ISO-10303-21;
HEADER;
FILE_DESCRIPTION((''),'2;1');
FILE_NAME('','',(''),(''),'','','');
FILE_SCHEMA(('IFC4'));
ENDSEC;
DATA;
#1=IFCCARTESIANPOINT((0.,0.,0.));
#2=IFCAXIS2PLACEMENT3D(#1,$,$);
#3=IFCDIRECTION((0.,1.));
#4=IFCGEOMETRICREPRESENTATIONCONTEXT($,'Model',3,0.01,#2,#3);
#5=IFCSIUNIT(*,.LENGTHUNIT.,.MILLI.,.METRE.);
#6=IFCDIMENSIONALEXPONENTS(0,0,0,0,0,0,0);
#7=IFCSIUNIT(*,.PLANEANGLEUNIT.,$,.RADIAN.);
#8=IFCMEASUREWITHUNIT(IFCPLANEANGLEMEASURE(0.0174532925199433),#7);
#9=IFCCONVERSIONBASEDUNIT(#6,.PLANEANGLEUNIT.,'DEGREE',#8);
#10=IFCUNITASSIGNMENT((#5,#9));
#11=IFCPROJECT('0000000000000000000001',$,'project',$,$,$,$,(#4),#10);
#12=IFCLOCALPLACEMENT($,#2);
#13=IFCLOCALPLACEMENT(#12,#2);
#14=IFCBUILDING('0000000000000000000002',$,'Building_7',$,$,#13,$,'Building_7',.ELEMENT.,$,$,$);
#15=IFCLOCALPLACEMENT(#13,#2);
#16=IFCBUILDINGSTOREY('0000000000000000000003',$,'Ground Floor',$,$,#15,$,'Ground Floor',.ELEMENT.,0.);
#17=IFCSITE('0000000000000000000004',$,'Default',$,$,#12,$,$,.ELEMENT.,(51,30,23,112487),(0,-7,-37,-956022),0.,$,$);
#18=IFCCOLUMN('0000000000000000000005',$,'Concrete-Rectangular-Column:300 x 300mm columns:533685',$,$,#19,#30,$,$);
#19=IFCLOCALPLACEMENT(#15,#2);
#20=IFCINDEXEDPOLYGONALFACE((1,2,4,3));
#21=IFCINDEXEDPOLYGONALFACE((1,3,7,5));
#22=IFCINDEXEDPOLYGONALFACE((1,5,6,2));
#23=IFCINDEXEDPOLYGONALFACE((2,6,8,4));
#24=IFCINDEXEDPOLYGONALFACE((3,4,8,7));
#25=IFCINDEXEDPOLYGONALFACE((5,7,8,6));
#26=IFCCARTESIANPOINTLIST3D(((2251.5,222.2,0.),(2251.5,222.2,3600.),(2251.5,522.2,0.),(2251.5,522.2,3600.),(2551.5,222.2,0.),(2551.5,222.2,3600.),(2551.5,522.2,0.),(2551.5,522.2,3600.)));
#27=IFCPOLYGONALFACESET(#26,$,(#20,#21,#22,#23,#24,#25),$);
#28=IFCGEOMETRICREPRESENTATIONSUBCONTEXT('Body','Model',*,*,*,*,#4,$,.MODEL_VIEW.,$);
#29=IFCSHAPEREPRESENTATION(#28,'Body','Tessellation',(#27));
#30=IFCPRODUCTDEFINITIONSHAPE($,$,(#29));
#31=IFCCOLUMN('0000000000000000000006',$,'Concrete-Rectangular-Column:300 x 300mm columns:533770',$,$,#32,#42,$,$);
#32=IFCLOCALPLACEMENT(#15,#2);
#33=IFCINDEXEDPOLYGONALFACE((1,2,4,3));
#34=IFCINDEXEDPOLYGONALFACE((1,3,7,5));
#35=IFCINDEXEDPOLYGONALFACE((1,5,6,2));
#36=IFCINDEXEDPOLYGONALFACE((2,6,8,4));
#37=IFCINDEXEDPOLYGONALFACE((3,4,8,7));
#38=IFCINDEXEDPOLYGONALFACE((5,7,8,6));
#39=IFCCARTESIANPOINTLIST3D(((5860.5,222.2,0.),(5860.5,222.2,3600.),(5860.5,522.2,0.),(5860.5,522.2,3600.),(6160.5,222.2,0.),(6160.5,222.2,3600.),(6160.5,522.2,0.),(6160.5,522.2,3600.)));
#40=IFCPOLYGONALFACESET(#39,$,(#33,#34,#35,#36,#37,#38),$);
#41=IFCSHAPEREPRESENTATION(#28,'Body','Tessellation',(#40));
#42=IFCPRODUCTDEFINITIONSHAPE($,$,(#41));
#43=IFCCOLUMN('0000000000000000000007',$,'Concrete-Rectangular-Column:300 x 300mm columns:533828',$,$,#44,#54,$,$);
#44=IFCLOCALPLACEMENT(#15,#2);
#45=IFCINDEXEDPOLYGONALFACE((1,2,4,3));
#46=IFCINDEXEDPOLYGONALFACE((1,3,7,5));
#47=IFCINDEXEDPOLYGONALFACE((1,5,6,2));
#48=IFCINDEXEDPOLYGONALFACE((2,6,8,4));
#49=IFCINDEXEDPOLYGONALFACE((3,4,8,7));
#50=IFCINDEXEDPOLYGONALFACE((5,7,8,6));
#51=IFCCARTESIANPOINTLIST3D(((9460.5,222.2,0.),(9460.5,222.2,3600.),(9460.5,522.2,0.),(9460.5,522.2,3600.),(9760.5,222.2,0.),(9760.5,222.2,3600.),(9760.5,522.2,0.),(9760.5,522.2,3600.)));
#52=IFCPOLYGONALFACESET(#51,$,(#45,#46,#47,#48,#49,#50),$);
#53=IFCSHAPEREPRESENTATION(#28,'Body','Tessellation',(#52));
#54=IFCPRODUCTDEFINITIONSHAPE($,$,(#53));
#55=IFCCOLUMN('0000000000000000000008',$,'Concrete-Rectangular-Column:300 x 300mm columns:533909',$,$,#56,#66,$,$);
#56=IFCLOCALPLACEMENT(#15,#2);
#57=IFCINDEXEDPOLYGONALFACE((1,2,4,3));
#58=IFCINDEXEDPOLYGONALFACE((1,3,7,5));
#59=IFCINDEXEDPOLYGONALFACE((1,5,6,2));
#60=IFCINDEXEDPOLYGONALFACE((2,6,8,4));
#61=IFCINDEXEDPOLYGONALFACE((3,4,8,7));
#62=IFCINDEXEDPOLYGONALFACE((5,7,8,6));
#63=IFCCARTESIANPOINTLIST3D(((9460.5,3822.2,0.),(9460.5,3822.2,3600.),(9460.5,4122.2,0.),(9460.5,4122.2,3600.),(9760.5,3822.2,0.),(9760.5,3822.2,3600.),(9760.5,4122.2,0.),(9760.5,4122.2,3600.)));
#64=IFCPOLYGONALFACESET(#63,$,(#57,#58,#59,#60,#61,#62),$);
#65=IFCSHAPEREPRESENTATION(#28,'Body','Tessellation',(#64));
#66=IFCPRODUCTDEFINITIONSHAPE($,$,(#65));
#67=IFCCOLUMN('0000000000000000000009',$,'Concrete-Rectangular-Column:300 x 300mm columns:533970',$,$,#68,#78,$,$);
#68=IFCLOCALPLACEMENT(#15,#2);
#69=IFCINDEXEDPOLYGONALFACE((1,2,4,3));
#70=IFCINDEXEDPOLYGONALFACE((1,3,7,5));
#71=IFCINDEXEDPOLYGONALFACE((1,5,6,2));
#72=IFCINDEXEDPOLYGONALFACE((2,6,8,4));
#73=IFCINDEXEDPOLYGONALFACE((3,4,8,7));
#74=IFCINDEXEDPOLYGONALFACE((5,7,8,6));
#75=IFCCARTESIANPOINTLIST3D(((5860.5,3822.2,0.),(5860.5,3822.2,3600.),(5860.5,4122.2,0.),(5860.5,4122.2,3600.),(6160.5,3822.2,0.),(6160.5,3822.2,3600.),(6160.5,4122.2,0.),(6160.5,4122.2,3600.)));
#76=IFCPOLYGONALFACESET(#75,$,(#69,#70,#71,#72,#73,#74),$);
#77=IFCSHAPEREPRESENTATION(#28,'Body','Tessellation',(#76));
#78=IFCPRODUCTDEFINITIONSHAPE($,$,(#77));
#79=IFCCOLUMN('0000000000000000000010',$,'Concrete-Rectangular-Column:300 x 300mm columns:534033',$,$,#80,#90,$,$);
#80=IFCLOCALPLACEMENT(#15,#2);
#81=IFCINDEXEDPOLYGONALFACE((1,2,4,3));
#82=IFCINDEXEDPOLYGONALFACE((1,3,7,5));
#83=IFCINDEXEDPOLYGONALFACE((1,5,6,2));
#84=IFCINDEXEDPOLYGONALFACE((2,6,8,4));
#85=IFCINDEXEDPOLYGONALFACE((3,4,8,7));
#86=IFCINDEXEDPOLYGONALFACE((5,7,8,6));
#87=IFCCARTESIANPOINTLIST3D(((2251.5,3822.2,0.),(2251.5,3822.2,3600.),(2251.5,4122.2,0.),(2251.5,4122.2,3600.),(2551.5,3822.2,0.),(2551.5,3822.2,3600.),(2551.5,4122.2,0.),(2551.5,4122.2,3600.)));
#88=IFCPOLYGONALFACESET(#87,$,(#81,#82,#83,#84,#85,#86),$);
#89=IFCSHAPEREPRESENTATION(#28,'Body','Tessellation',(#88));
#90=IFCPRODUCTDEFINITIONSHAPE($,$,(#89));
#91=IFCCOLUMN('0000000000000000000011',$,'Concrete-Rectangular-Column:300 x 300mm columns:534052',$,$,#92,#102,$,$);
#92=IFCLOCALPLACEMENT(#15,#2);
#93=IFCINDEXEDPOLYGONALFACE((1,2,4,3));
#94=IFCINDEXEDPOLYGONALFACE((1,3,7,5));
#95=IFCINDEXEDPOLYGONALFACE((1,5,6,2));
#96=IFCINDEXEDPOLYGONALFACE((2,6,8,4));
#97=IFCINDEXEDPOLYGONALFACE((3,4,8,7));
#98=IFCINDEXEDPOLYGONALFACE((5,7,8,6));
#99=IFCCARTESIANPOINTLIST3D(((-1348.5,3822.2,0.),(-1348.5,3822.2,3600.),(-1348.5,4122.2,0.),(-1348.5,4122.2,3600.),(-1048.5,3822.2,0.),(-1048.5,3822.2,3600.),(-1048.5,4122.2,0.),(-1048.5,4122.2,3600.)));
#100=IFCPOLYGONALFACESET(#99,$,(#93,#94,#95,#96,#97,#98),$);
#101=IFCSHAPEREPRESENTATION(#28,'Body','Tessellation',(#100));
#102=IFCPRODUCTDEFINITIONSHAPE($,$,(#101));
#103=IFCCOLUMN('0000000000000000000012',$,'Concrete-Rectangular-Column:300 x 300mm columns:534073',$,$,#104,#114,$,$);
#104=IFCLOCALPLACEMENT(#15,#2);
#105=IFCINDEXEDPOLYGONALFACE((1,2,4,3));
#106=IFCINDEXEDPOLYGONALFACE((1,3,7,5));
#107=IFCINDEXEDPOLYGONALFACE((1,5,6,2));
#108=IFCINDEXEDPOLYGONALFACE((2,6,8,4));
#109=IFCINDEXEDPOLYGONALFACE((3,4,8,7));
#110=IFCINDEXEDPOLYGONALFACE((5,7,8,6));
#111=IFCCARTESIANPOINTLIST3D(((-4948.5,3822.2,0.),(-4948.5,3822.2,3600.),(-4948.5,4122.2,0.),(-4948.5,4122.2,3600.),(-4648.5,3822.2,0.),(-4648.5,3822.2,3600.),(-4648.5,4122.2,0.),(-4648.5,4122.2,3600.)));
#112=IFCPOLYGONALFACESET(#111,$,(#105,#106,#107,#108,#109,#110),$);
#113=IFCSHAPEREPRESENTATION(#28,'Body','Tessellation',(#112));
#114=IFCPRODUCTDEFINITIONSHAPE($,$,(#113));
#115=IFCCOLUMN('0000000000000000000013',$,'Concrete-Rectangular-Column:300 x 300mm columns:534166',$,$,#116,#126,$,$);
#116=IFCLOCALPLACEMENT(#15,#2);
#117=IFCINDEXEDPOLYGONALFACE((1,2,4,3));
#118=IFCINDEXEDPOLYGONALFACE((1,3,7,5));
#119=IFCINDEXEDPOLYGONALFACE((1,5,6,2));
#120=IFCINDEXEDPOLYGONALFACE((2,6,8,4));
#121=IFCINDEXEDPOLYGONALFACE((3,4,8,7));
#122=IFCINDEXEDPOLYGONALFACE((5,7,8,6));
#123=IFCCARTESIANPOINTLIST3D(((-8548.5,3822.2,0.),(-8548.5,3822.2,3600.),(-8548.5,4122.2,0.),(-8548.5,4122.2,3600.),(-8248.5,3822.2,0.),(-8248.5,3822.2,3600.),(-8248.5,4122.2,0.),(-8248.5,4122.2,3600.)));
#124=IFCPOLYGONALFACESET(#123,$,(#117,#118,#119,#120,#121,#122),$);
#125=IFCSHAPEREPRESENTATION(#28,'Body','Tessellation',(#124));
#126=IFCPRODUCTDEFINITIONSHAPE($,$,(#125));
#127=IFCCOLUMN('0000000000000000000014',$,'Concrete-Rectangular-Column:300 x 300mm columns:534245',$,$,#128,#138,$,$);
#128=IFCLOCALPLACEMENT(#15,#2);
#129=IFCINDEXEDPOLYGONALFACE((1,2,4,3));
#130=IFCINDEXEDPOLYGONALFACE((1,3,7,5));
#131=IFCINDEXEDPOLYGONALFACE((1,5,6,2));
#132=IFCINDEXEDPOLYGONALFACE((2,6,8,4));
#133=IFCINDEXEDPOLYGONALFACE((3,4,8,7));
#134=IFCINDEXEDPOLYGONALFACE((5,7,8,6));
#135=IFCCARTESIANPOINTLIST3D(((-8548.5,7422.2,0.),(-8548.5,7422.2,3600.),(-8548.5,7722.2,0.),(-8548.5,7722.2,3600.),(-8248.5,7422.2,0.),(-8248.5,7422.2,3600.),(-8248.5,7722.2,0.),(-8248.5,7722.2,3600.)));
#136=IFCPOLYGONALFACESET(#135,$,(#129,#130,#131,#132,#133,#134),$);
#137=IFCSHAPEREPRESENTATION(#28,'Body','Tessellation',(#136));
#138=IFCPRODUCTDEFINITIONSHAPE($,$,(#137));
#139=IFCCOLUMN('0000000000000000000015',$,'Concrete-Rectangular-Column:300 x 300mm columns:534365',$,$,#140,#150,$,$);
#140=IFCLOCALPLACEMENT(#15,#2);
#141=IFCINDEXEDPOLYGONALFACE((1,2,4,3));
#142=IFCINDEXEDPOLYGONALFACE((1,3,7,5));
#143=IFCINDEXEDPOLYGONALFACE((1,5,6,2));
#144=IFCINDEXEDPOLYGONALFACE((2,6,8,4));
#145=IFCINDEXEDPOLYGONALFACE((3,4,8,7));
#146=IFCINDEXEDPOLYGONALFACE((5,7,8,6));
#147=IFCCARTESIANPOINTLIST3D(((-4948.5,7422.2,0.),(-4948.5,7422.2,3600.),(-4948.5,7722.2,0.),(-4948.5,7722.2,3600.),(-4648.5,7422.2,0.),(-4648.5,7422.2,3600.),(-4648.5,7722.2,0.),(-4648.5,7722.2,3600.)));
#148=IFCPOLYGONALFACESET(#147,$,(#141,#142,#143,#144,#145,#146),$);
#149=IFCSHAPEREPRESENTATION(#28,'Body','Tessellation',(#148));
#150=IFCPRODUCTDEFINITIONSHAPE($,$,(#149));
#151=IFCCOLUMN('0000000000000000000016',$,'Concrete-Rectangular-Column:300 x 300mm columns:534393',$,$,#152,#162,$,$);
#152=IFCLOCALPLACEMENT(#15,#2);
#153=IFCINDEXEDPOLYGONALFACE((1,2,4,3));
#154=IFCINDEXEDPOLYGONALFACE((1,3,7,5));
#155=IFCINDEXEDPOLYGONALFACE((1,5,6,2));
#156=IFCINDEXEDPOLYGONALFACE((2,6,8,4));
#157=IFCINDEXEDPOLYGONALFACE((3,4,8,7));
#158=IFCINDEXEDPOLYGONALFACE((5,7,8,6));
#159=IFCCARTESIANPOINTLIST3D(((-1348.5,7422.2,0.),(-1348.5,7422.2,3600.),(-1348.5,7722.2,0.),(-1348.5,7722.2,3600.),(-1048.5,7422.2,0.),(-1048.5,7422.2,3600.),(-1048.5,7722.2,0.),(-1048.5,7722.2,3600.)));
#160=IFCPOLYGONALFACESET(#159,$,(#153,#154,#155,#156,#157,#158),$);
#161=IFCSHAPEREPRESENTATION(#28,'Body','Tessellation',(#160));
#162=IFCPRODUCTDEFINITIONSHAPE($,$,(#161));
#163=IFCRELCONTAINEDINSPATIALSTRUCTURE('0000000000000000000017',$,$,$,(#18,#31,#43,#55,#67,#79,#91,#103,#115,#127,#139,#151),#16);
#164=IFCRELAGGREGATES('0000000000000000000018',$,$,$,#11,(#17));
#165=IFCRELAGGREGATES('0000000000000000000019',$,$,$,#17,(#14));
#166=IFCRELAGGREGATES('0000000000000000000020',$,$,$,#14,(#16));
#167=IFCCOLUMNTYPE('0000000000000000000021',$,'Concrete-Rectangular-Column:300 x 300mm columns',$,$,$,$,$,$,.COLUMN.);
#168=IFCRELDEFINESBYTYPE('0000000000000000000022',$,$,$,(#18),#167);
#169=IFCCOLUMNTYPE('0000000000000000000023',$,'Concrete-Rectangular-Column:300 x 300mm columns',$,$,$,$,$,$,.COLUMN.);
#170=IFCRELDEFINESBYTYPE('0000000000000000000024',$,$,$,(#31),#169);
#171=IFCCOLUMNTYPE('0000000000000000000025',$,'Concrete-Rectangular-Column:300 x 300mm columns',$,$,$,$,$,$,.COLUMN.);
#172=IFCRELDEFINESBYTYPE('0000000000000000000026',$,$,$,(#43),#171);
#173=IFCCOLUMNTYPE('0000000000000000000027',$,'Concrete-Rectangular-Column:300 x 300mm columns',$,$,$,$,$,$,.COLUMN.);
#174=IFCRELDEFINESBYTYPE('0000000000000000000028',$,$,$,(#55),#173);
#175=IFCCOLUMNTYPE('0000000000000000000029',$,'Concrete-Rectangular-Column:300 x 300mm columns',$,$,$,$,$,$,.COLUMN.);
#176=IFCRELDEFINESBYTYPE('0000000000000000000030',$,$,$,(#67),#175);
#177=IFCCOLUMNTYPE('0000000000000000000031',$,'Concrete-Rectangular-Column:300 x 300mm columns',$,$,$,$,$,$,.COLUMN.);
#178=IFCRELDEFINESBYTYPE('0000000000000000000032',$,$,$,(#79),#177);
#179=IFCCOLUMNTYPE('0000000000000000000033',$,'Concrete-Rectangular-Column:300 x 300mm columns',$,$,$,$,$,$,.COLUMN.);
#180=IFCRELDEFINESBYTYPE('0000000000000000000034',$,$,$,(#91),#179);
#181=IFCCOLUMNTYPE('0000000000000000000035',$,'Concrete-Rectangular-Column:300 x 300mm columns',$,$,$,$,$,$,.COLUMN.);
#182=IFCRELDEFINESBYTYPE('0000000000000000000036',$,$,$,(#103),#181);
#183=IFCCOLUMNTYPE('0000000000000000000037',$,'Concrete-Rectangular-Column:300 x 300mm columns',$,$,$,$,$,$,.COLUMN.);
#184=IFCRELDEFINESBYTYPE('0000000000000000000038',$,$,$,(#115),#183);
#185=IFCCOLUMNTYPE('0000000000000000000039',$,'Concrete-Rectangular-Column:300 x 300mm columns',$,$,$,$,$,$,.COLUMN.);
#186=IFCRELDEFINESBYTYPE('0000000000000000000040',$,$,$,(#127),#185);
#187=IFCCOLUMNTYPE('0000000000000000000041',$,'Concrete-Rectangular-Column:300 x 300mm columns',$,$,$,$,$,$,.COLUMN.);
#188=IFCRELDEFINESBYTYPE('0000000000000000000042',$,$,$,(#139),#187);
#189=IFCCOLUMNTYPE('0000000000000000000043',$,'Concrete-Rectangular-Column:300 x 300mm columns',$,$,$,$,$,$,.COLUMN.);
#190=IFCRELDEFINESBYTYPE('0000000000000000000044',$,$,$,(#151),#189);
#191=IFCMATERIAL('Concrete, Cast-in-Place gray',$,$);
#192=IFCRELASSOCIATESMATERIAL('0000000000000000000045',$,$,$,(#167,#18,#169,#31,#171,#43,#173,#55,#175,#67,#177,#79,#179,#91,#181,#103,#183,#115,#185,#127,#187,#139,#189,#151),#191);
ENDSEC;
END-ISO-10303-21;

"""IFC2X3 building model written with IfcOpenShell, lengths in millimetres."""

from ifc_helpers import new_model, entity, si_unit, converted_unit, direction, frame, frame_2d, origin, origin_2d_with_axis, place, context, subcontext, project, spatial, rectangle, extrude, source, transform, mapped, material, type_object, type_shapes, element, save


model = new_model("IFC2X3")

# Units and contexts
model_context = context("Model", 3, precision=0.01, world=origin(), true_north=direction((0.0, 1.0)))
body_context = subcontext(model_context, "Body", "Model", "MODEL_VIEW")
ifc_project = project(units=[si_unit("LENGTHUNIT", "METRE", prefix="MILLI"), converted_unit("PLANEANGLEUNIT", "DEGREE", entity("IfcPlaneAngleMeasure", 0.0174532925199433), si_unit("PLANEANGLEUNIT", "RADIAN"), dimensions=[0, 0, 0, 0, 0, 0, 0])], contexts=[model_context])

# Site, building, storey
site_placement = place(None, origin())
site = spatial("IfcSite", under=ifc_project, at=site_placement, Name="Default", CompositionType="ELEMENT", RefLatitude=(51, 30, 23, 112487), RefLongitude=(0, -7, -37, -956022), RefElevation=0.0)
building_placement = place(site_placement, origin())
building = spatial("IfcBuilding", under=site, at=building_placement, Name="Building_7", LongName="Building_7", CompositionType="ELEMENT")
storey_placement = place(building_placement, origin())
storey = spatial("IfcBuildingStorey", under=building, at=storey_placement, Name="Ground Floor", LongName="Ground Floor", CompositionType="ELEMENT", Elevation=0.0)

# Columns
ifc_material_1 = material(Name="Concrete, Cast-in-Place gray")
column_type_1 = type_object("IfcColumnType", Name="Concrete-Rectangular-Column:300 x 300mm columns", PredefinedType="COLUMN", material=ifc_material_1)
shared_shape_1 = source(origin(), body_context, "Body", "SweptSolid", [
    extrude(rectangle(XDim=300.0, YDim=300.0, at=frame_2d((0.0, 0.0), x_axis=(1.0, 0.0))), frame((2401.5, 372.2, 0.0), z_axis=(0.0, 0.0, 1.0), x_axis=(-1.0, 0.0, 0.0)), (0.0, 0.0, 1.0), 3600.0),
])
type_shapes(column_type_1, [shared_shape_1])
column_1_placement = place(storey_placement, origin())
element("IfcColumn", 1, at=column_1_placement, inside=storey, type_object=column_type_1, material=ifc_material_1, Name="Concrete-Rectangular-Column:300 x 300mm columns:533685", context=body_context, shape_type="MappedRepresentation", body=[
    mapped(shared_shape_1, transform((0.0, 0.0, 0.0), scale=1.0)),
])
column_type_2 = type_object("IfcColumnType", Name="Concrete-Rectangular-Column:300 x 300mm columns", PredefinedType="COLUMN", material=ifc_material_1)
shared_shape_2 = source(origin(), body_context, "Body", "SweptSolid", [
    extrude(rectangle(XDim=300.0, YDim=300.0, at=frame_2d((0.0, 0.0), x_axis=(1.0, 0.0))), frame((6010.5, 372.2, 0.0), z_axis=(0.0, 0.0, 1.0), x_axis=(-1.0, 0.0, 0.0)), (0.0, 0.0, 1.0), 3600.0),
])
type_shapes(column_type_2, [shared_shape_2])
column_2_placement = place(storey_placement, origin())
element("IfcColumn", 2, at=column_2_placement, inside=storey, type_object=column_type_2, material=ifc_material_1, Name="Concrete-Rectangular-Column:300 x 300mm columns:533770", context=body_context, shape_type="MappedRepresentation", body=[
    mapped(shared_shape_2, transform((0.0, 0.0, 0.0), scale=1.0)),
])
column_type_3 = type_object("IfcColumnType", Name="Concrete-Rectangular-Column:300 x 300mm columns", PredefinedType="COLUMN", material=ifc_material_1)
shared_shape_3 = source(origin(), body_context, "Body", "SweptSolid", [
    extrude(rectangle(XDim=300.0, YDim=300.0, at=frame_2d((0.0, 0.0), x_axis=(1.0, 0.0))), frame((9610.5, 372.2, 0.0), z_axis=(0.0, 0.0, 1.0), x_axis=(-1.0, 0.0, 0.0)), (0.0, 0.0, 1.0), 3600.0),
])
type_shapes(column_type_3, [shared_shape_3])
column_3_placement = place(storey_placement, origin())
element("IfcColumn", 3, at=column_3_placement, inside=storey, type_object=column_type_3, material=ifc_material_1, Name="Concrete-Rectangular-Column:300 x 300mm columns:533828", context=body_context, shape_type="MappedRepresentation", body=[
    mapped(shared_shape_3, transform((0.0, 0.0, 0.0), scale=1.0)),
])
column_type_4 = type_object("IfcColumnType", Name="Concrete-Rectangular-Column:300 x 300mm columns", PredefinedType="COLUMN", material=ifc_material_1)
shared_shape_4 = source(origin(), body_context, "Body", "SweptSolid", [
    extrude(rectangle(XDim=300.0, YDim=300.0, at=origin_2d_with_axis()), frame((9610.5, 3972.2, 0.0), z_axis=(0.0, 0.0, 1.0), x_axis=(-1.0, 0.0, 0.0)), (0.0, 0.0, 1.0), 3600.0),
])
type_shapes(column_type_4, [shared_shape_4])
column_4_placement = place(storey_placement, origin())
element("IfcColumn", 4, at=column_4_placement, inside=storey, type_object=column_type_4, material=ifc_material_1, Name="Concrete-Rectangular-Column:300 x 300mm columns:533909", context=body_context, shape_type="MappedRepresentation", body=[
    mapped(shared_shape_4, transform((0.0, 0.0, 0.0), scale=1.0)),
])
column_type_5 = type_object("IfcColumnType", Name="Concrete-Rectangular-Column:300 x 300mm columns", PredefinedType="COLUMN", material=ifc_material_1)
shared_shape_5 = source(origin(), body_context, "Body", "SweptSolid", [
    extrude(rectangle(XDim=300.0, YDim=300.0, at=frame_2d((0.0, 0.0), x_axis=(1.0, 0.0))), frame((6010.5, 3972.2, 0.0), z_axis=(0.0, 0.0, 1.0), x_axis=(-1.0, 0.0, 0.0)), (0.0, 0.0, 1.0), 3600.0),
])
type_shapes(column_type_5, [shared_shape_5])
column_5_placement = place(storey_placement, origin())
element("IfcColumn", 5, at=column_5_placement, inside=storey, type_object=column_type_5, material=ifc_material_1, Name="Concrete-Rectangular-Column:300 x 300mm columns:533970", context=body_context, shape_type="MappedRepresentation", body=[
    mapped(shared_shape_5, transform((0.0, 0.0, 0.0), scale=1.0)),
])
column_type_6 = type_object("IfcColumnType", Name="Concrete-Rectangular-Column:300 x 300mm columns", PredefinedType="COLUMN", material=ifc_material_1)
shared_shape_6 = source(origin(), body_context, "Body", "SweptSolid", [
    extrude(rectangle(XDim=300.0, YDim=300.0, at=frame_2d((0.0, 0.0), x_axis=(1.0, 0.0))), frame((2401.5, 3972.2, 0.0), z_axis=(0.0, 0.0, 1.0), x_axis=(-1.0, 0.0, 0.0)), (0.0, 0.0, 1.0), 3600.0),
])
type_shapes(column_type_6, [shared_shape_6])
column_6_placement = place(storey_placement, origin())
element("IfcColumn", 6, at=column_6_placement, inside=storey, type_object=column_type_6, material=ifc_material_1, Name="Concrete-Rectangular-Column:300 x 300mm columns:534033", context=body_context, shape_type="MappedRepresentation", body=[
    mapped(shared_shape_6, transform((0.0, 0.0, 0.0), scale=1.0)),
])
column_type_7 = type_object("IfcColumnType", Name="Concrete-Rectangular-Column:300 x 300mm columns", PredefinedType="COLUMN", material=ifc_material_1)
shared_shape_7 = source(origin(), body_context, "Body", "SweptSolid", [
    extrude(rectangle(XDim=300.0, YDim=300.0, at=origin_2d_with_axis()), frame((-1198.5, 3972.2, 0.0), z_axis=(0.0, 0.0, 1.0), x_axis=(-1.0, 0.0, 0.0)), (0.0, 0.0, 1.0), 3600.0),
])
type_shapes(column_type_7, [shared_shape_7])
column_7_placement = place(storey_placement, origin())
element("IfcColumn", 7, at=column_7_placement, inside=storey, type_object=column_type_7, material=ifc_material_1, Name="Concrete-Rectangular-Column:300 x 300mm columns:534052", context=body_context, shape_type="MappedRepresentation", body=[
    mapped(shared_shape_7, transform((0.0, 0.0, 0.0), scale=1.0)),
])
column_type_8 = type_object("IfcColumnType", Name="Concrete-Rectangular-Column:300 x 300mm columns", PredefinedType="COLUMN", material=ifc_material_1)
shared_shape_8 = source(origin(), body_context, "Body", "SweptSolid", [
    extrude(rectangle(XDim=300.0, YDim=300.0, at=origin_2d_with_axis()), frame((-4798.5, 3972.2, 0.0), z_axis=(0.0, 0.0, 1.0), x_axis=(-1.0, 0.0, 0.0)), (0.0, 0.0, 1.0), 3600.0),
])
type_shapes(column_type_8, [shared_shape_8])
column_8_placement = place(storey_placement, origin())
element("IfcColumn", 8, at=column_8_placement, inside=storey, type_object=column_type_8, material=ifc_material_1, Name="Concrete-Rectangular-Column:300 x 300mm columns:534073", context=body_context, shape_type="MappedRepresentation", body=[
    mapped(shared_shape_8, transform((0.0, 0.0, 0.0), scale=1.0)),
])
column_type_9 = type_object("IfcColumnType", Name="Concrete-Rectangular-Column:300 x 300mm columns", PredefinedType="COLUMN", material=ifc_material_1)
shared_shape_9 = source(origin(), body_context, "Body", "SweptSolid", [
    extrude(rectangle(XDim=300.0, YDim=300.0, at=frame_2d((0.0, 0.0), x_axis=(1.0, 0.0))), frame((-8398.5, 3972.2, 0.0), z_axis=(0.0, 0.0, 1.0), x_axis=(-1.0, 0.0, 0.0)), (0.0, 0.0, 1.0), 3600.0),
])
type_shapes(column_type_9, [shared_shape_9])
column_9_placement = place(storey_placement, origin())
element("IfcColumn", 9, at=column_9_placement, inside=storey, type_object=column_type_9, material=ifc_material_1, Name="Concrete-Rectangular-Column:300 x 300mm columns:534166", context=body_context, shape_type="MappedRepresentation", body=[
    mapped(shared_shape_9, transform((0.0, 0.0, 0.0), scale=1.0)),
])
column_type_10 = type_object("IfcColumnType", Name="Concrete-Rectangular-Column:300 x 300mm columns", PredefinedType="COLUMN", material=ifc_material_1)
shared_shape_10 = source(origin(), body_context, "Body", "SweptSolid", [
    extrude(rectangle(XDim=300.0, YDim=300.0, at=frame_2d((0.0, 0.0), x_axis=(1.0, 0.0))), frame((-8398.5, 7572.2, 0.0), z_axis=(0.0, 0.0, 1.0), x_axis=(-1.0, 0.0, 0.0)), (0.0, 0.0, 1.0), 3600.0),
])
type_shapes(column_type_10, [shared_shape_10])
column_10_placement = place(storey_placement, origin())
element("IfcColumn", 10, at=column_10_placement, inside=storey, type_object=column_type_10, material=ifc_material_1, Name="Concrete-Rectangular-Column:300 x 300mm columns:534245", context=body_context, shape_type="MappedRepresentation", body=[
    mapped(shared_shape_10, transform((0.0, 0.0, 0.0), scale=1.0)),
])
column_type_11 = type_object("IfcColumnType", Name="Concrete-Rectangular-Column:300 x 300mm columns", PredefinedType="COLUMN", material=ifc_material_1)
shared_shape_11 = source(origin(), body_context, "Body", "SweptSolid", [
    extrude(rectangle(XDim=300.0, YDim=300.0, at=frame_2d((0.0, 0.0), x_axis=(1.0, 0.0))), frame((-4798.5, 7572.2, 0.0), z_axis=(0.0, 0.0, 1.0), x_axis=(-1.0, 0.0, 0.0)), (0.0, 0.0, 1.0), 3600.0),
])
type_shapes(column_type_11, [shared_shape_11])
column_11_placement = place(storey_placement, origin())
element("IfcColumn", 11, at=column_11_placement, inside=storey, type_object=column_type_11, material=ifc_material_1, Name="Concrete-Rectangular-Column:300 x 300mm columns:534365", context=body_context, shape_type="MappedRepresentation", body=[
    mapped(shared_shape_11, transform((0.0, 0.0, 0.0), scale=1.0)),
])
column_type_12 = type_object("IfcColumnType", Name="Concrete-Rectangular-Column:300 x 300mm columns", PredefinedType="COLUMN", material=ifc_material_1)
shared_shape_12 = source(origin(), body_context, "Body", "SweptSolid", [
    extrude(rectangle(XDim=300.0, YDim=300.0, at=frame_2d((0.0, 0.0), x_axis=(1.0, 0.0))), frame((-1198.5, 7572.2, 0.0), z_axis=(0.0, 0.0, 1.0), x_axis=(-1.0, 0.0, 0.0)), (0.0, 0.0, 1.0), 3600.0),
])
type_shapes(column_type_12, [shared_shape_12])
column_12_placement = place(storey_placement, origin())
element("IfcColumn", 12, at=column_12_placement, inside=storey, type_object=column_type_12, material=ifc_material_1, Name="Concrete-Rectangular-Column:300 x 300mm columns:534393", context=body_context, shape_type="MappedRepresentation", body=[
    mapped(shared_shape_12, transform((0.0, 0.0, 0.0), scale=1.0)),
])

save(model, "model.ifc")
